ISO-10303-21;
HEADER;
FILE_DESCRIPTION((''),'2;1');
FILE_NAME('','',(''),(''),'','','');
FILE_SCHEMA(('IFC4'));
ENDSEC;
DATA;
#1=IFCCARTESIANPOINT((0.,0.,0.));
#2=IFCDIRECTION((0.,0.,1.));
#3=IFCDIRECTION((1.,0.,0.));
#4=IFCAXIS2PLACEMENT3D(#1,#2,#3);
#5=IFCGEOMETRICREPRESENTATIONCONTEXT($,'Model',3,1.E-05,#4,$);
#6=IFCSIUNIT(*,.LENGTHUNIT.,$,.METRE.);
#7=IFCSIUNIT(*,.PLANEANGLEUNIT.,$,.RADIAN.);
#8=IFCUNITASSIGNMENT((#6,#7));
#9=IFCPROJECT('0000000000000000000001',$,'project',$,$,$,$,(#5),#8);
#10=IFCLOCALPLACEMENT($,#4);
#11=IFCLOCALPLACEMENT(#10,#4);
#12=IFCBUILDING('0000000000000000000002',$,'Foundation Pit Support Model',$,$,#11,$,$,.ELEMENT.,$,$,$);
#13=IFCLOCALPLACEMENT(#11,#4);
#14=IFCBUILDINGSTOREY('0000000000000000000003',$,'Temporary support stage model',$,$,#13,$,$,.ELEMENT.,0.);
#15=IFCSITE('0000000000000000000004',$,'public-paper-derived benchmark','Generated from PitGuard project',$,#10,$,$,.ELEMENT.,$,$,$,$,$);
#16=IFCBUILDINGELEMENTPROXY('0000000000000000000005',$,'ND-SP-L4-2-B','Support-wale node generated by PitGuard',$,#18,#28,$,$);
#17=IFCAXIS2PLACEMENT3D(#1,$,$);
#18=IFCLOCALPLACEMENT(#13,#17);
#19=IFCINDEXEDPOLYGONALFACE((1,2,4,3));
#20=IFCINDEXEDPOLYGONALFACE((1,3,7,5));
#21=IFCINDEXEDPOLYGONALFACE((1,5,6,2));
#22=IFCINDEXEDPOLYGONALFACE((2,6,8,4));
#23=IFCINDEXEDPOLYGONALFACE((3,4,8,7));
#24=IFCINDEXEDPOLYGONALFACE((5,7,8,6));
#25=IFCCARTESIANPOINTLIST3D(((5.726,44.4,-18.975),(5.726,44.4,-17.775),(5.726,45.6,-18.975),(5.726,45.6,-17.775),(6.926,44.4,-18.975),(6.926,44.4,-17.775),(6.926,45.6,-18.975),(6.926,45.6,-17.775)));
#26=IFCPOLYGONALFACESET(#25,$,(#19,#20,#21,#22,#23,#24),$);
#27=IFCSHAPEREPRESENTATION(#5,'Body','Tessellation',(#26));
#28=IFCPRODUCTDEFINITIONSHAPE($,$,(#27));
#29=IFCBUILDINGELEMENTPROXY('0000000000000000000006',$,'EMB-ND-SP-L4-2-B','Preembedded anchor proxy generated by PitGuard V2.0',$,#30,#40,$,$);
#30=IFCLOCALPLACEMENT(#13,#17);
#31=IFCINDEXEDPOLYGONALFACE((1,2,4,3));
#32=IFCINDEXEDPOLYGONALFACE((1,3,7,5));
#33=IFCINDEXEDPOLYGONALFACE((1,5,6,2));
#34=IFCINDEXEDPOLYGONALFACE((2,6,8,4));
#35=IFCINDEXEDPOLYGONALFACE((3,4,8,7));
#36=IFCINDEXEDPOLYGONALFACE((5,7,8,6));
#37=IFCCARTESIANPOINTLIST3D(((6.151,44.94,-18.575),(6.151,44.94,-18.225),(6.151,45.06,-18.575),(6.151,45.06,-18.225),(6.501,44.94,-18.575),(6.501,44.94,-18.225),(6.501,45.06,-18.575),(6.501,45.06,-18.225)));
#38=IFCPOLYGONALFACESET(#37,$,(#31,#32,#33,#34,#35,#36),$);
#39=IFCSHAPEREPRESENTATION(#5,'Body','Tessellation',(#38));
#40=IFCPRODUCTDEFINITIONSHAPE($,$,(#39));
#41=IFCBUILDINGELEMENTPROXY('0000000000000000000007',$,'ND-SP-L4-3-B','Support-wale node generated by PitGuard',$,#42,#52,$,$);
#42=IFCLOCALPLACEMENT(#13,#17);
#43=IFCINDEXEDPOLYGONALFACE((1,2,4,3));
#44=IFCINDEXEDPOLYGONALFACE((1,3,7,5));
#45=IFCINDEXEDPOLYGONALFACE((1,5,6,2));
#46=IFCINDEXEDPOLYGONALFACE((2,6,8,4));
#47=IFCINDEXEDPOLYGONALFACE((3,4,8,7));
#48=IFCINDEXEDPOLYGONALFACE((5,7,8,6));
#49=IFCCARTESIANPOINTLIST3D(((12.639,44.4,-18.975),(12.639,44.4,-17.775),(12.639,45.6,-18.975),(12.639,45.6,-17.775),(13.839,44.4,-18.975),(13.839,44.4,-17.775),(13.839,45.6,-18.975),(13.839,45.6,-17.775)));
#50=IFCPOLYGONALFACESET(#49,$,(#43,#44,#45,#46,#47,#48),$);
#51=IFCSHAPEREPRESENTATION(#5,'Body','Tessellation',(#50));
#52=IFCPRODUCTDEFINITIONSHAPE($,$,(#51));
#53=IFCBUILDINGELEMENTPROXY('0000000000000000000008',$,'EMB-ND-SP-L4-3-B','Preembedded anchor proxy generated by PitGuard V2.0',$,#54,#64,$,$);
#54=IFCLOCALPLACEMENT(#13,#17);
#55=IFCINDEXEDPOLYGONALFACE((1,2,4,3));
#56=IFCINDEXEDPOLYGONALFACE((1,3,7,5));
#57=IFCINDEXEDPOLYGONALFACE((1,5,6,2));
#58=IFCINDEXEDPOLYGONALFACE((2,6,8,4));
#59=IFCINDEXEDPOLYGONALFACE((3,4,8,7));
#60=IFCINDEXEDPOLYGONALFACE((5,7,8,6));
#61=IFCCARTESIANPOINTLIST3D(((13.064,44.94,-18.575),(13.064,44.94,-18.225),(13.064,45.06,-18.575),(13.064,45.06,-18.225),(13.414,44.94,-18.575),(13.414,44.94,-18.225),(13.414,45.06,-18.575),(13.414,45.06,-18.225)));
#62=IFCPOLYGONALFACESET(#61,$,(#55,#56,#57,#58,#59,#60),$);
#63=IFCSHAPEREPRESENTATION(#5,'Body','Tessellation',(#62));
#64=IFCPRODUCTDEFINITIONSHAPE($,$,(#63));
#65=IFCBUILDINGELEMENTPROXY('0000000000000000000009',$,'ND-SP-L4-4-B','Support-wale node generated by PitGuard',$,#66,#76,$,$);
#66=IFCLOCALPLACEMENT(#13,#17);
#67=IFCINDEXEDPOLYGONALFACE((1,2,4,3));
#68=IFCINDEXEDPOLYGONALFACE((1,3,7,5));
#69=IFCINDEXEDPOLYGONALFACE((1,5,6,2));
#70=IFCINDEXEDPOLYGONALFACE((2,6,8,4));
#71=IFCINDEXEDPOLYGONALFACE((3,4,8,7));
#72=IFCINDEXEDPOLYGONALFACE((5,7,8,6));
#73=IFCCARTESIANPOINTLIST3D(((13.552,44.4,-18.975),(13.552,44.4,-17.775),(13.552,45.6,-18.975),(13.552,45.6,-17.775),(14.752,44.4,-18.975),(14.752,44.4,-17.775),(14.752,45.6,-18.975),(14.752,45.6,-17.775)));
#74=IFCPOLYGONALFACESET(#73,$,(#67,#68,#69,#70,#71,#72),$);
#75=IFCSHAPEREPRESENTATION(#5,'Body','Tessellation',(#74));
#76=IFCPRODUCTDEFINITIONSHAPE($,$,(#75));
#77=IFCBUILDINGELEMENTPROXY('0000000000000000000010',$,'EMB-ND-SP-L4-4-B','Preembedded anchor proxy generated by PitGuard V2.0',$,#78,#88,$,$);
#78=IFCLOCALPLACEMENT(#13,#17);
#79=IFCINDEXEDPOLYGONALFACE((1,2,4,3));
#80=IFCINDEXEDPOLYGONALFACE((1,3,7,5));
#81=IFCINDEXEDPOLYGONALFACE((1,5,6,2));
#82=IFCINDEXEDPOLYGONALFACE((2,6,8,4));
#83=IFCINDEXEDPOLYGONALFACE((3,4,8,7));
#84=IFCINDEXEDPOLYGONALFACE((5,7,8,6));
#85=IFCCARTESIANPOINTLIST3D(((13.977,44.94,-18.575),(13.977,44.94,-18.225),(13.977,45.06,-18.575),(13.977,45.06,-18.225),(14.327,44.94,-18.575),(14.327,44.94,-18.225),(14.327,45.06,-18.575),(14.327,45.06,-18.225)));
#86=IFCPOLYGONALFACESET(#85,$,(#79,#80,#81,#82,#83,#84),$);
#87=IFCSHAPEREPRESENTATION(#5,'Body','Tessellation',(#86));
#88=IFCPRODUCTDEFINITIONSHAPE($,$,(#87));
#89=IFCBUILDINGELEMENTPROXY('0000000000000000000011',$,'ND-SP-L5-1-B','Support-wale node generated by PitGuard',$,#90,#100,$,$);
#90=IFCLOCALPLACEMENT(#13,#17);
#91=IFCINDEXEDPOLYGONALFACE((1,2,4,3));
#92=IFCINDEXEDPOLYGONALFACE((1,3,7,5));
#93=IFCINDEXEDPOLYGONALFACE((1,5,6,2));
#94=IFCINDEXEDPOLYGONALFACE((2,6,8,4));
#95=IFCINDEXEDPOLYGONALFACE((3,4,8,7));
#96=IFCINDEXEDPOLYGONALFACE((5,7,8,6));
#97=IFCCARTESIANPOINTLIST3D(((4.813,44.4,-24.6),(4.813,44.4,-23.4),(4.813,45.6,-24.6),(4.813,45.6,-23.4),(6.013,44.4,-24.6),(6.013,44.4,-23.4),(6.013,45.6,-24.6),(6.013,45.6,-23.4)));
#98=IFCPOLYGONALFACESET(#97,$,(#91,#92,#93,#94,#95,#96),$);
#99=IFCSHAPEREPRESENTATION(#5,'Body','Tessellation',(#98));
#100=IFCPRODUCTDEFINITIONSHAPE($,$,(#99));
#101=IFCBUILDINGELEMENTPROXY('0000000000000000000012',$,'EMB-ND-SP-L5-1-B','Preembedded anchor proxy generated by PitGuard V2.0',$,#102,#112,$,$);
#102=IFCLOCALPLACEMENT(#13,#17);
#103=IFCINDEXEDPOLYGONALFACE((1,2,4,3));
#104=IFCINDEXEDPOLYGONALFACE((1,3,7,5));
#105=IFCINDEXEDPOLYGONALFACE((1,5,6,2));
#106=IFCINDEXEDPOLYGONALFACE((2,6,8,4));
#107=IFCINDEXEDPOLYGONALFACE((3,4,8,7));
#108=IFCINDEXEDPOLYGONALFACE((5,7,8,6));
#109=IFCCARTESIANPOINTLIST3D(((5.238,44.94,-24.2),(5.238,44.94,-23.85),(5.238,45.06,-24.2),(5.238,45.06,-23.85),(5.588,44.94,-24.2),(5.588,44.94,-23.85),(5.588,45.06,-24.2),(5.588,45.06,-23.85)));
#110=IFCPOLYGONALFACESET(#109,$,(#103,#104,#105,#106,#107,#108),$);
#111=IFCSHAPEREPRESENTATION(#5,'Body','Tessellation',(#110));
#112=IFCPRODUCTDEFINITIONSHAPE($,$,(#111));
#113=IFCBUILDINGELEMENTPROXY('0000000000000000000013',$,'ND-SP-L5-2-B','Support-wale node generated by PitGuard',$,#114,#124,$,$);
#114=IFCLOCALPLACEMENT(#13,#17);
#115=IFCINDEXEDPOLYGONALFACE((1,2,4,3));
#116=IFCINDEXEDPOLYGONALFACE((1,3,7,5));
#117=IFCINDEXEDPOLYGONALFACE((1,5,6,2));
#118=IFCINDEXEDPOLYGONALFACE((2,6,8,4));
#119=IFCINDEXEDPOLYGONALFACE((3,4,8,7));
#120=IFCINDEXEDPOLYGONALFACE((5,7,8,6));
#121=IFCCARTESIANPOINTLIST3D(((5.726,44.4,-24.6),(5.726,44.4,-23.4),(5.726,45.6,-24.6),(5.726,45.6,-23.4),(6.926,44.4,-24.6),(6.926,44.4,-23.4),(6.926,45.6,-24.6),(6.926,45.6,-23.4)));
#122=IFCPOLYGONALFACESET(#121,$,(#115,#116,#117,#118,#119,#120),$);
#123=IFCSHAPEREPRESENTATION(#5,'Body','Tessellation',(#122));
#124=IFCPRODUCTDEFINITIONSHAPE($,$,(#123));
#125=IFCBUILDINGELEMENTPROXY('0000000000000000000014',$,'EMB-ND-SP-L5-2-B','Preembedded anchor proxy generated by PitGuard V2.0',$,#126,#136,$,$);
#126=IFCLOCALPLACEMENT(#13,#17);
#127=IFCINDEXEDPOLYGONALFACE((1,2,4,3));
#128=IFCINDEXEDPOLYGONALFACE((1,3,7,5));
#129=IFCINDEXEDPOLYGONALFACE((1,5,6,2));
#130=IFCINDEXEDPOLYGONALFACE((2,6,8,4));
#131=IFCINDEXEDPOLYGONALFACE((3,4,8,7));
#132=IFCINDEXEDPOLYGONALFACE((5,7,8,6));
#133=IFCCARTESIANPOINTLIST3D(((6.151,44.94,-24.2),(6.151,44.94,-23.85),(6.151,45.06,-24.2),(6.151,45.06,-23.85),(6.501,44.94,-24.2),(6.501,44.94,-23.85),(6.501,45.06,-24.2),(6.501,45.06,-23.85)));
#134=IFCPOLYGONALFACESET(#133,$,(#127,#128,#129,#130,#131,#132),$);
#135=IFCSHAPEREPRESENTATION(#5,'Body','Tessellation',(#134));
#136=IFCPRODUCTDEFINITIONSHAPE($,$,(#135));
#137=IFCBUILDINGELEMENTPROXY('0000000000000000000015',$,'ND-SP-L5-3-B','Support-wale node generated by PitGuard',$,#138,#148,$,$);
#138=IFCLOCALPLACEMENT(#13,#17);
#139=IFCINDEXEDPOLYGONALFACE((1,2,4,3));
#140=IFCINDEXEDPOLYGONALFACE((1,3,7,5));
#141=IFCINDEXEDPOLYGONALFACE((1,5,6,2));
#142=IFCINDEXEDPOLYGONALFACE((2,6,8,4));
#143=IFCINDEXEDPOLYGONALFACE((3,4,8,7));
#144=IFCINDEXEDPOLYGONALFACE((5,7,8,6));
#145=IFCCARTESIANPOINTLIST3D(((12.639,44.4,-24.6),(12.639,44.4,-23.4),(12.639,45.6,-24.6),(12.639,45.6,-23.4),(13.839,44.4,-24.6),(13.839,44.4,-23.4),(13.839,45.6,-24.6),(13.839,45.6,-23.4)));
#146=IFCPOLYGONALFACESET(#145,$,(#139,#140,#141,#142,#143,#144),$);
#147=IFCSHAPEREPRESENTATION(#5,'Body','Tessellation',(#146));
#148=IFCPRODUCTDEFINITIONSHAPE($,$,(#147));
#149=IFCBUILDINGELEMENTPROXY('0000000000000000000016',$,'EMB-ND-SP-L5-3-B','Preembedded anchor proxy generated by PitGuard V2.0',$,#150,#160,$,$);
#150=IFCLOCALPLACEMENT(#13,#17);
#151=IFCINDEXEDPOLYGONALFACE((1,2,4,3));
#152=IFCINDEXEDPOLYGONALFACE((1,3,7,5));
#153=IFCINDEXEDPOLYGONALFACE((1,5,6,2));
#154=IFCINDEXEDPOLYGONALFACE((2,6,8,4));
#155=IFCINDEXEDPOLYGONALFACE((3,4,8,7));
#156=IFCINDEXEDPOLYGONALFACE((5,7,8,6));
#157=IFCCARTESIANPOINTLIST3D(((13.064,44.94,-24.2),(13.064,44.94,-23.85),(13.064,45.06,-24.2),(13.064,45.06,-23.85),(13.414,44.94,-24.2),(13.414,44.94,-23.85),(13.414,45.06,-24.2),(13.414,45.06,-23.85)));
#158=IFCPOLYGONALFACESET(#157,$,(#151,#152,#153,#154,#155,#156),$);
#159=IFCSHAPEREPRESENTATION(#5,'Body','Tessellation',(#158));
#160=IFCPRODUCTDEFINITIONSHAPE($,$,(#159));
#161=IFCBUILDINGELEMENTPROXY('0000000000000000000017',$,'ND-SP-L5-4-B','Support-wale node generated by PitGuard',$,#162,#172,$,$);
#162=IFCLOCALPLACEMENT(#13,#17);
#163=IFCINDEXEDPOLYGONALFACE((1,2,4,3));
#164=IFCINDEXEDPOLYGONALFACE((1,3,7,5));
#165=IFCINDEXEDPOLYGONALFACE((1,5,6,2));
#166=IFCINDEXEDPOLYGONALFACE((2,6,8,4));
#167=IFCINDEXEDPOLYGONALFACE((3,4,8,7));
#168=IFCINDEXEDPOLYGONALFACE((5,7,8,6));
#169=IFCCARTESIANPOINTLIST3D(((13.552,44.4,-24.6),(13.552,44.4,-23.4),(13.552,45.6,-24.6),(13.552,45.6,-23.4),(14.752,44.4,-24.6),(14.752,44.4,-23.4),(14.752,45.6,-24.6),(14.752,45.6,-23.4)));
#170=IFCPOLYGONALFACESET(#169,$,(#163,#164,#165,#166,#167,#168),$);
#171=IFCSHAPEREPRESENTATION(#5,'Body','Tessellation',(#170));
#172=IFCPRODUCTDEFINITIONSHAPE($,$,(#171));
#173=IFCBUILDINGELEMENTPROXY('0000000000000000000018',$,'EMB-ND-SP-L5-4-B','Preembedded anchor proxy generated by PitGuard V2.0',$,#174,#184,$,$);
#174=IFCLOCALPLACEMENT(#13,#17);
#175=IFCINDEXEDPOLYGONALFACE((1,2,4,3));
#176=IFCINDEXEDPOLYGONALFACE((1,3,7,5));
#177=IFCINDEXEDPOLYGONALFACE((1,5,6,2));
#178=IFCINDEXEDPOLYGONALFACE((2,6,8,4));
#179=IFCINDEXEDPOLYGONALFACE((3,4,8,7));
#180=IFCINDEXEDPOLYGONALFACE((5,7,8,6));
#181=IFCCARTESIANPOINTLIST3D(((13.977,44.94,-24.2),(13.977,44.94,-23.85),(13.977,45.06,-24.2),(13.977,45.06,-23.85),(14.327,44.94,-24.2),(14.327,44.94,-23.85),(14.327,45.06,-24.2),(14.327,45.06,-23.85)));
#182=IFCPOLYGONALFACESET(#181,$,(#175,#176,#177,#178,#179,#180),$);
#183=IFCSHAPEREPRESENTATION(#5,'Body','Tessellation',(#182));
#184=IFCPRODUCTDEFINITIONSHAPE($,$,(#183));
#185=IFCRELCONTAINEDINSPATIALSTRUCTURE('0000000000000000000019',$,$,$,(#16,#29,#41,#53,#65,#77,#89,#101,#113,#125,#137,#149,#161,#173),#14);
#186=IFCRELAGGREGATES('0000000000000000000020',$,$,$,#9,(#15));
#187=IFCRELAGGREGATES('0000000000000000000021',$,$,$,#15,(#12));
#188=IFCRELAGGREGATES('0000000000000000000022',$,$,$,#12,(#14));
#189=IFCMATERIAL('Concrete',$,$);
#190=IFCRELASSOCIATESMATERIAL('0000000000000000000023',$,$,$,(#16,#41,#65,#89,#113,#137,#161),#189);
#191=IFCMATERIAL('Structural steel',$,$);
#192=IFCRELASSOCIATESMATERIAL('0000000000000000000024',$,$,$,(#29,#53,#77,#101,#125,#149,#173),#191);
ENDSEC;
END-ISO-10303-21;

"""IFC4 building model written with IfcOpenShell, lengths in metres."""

from ifc_helpers import new_model, si_unit, frame, origin_with_axes, origin_2d, place, context, project, spatial, rectangle, extrude, material, element, save


model = new_model("IFC4")

# Units and contexts
model_context = context("Model", 3, precision=1e-05, world=origin_with_axes())
ifc_project = project(units=[si_unit("LENGTHUNIT", "METRE"), si_unit("PLANEANGLEUNIT", "RADIAN")], contexts=[model_context])

# Site, building, storey
site_placement = place(None, origin_with_axes())
site = spatial("IfcSite", under=ifc_project, at=site_placement, Name="public-paper-derived benchmark", Description="Generated from PitGuard project", CompositionType="ELEMENT")
building_placement = place(site_placement, origin_with_axes())
building = spatial("IfcBuilding", under=site, at=building_placement, Name="Foundation Pit Support Model", CompositionType="ELEMENT")
storey_placement = place(building_placement, origin_with_axes())
storey = spatial("IfcBuildingStorey", under=building, at=storey_placement, Name="Temporary support stage model", CompositionType="ELEMENT", Elevation=0.0)

# Shared definitions
ifc_material_1 = material(Name="Structural steel")

# Building element proxies
ifc_material_2 = material(Name="Concrete")
proxy_1_placement = place(storey_placement, frame((6.326, 45.0, -18.975), z_axis=(0.0, 0.0, 1.0), x_axis=(1.0, 0.0, 0.0)))
element("IfcBuildingElementProxy", 1, at=proxy_1_placement, inside=storey, material=ifc_material_2, Name="ND-SP-L4-2-B", Description="Support-wale node generated by PitGuard", context=model_context, shape_type="SweptSolid", body=[
    extrude(rectangle(XDim=1.2, YDim=1.2, at=origin_2d()), origin_with_axes(), (0.0, 0.0, 1.0), 1.2),
])
proxy_2_placement = place(storey_placement, frame((6.326, 45.0, -18.575), z_axis=(0.0, 0.0, 1.0), x_axis=(1.0, 0.0, 0.0)))
element("IfcBuildingElementProxy", 2, at=proxy_2_placement, inside=storey, material=ifc_material_1, Name="EMB-ND-SP-L4-2-B", Description="Preembedded anchor proxy generated by PitGuard V2.0", context=model_context, shape_type="SweptSolid", body=[
    extrude(rectangle(XDim=0.35, YDim=0.12, at=origin_2d()), origin_with_axes(), (0.0, 0.0, 1.0), 0.35),
])
proxy_3_placement = place(storey_placement, frame((13.239, 45.0, -18.975), z_axis=(0.0, 0.0, 1.0), x_axis=(1.0, 0.0, 0.0)))
element("IfcBuildingElementProxy", 3, at=proxy_3_placement, inside=storey, material=ifc_material_2, Name="ND-SP-L4-3-B", Description="Support-wale node generated by PitGuard", context=model_context, shape_type="SweptSolid", body=[
    extrude(rectangle(XDim=1.2, YDim=1.2, at=origin_2d()), origin_with_axes(), (0.0, 0.0, 1.0), 1.2),
])
proxy_4_placement = place(storey_placement, frame((13.239, 45.0, -18.575), z_axis=(0.0, 0.0, 1.0), x_axis=(1.0, 0.0, 0.0)))
element("IfcBuildingElementProxy", 4, at=proxy_4_placement, inside=storey, material=ifc_material_1, Name="EMB-ND-SP-L4-3-B", Description="Preembedded anchor proxy generated by PitGuard V2.0", context=model_context, shape_type="SweptSolid", body=[
    extrude(rectangle(XDim=0.35, YDim=0.12, at=origin_2d()), origin_with_axes(), (0.0, 0.0, 1.0), 0.35),
])
proxy_5_placement = place(storey_placement, frame((14.152, 45.0, -18.975), z_axis=(0.0, 0.0, 1.0), x_axis=(1.0, 0.0, 0.0)))
element("IfcBuildingElementProxy", 5, at=proxy_5_placement, inside=storey, material=ifc_material_2, Name="ND-SP-L4-4-B", Description="Support-wale node generated by PitGuard", context=model_context, shape_type="SweptSolid", body=[
    extrude(rectangle(XDim=1.2, YDim=1.2, at=origin_2d()), origin_with_axes(), (0.0, 0.0, 1.0), 1.2),
])
proxy_6_placement = place(storey_placement, frame((14.152, 45.0, -18.575), z_axis=(0.0, 0.0, 1.0), x_axis=(1.0, 0.0, 0.0)))
element("IfcBuildingElementProxy", 6, at=proxy_6_placement, inside=storey, material=ifc_material_1, Name="EMB-ND-SP-L4-4-B", Description="Preembedded anchor proxy generated by PitGuard V2.0", context=model_context, shape_type="SweptSolid", body=[
    extrude(rectangle(XDim=0.35, YDim=0.12, at=origin_2d()), origin_with_axes(), (0.0, 0.0, 1.0), 0.35),
])
proxy_7_placement = place(storey_placement, frame((5.413, 45.0, -24.6), z_axis=(0.0, 0.0, 1.0), x_axis=(1.0, 0.0, 0.0)))
element("IfcBuildingElementProxy", 7, at=proxy_7_placement, inside=storey, material=ifc_material_2, Name="ND-SP-L5-1-B", Description="Support-wale node generated by PitGuard", context=model_context, shape_type="SweptSolid", body=[
    extrude(rectangle(XDim=1.2, YDim=1.2, at=origin_2d()), origin_with_axes(), (0.0, 0.0, 1.0), 1.2),
])
proxy_8_placement = place(storey_placement, frame((5.413, 45.0, -24.2), z_axis=(0.0, 0.0, 1.0), x_axis=(1.0, 0.0, 0.0)))
element("IfcBuildingElementProxy", 8, at=proxy_8_placement, inside=storey, material=ifc_material_1, Name="EMB-ND-SP-L5-1-B", Description="Preembedded anchor proxy generated by PitGuard V2.0", context=model_context, shape_type="SweptSolid", body=[
    extrude(rectangle(XDim=0.35, YDim=0.12, at=origin_2d()), origin_with_axes(), (0.0, 0.0, 1.0), 0.35),
])
proxy_9_placement = place(storey_placement, frame((6.326, 45.0, -24.6), z_axis=(0.0, 0.0, 1.0), x_axis=(1.0, 0.0, 0.0)))
element("IfcBuildingElementProxy", 9, at=proxy_9_placement, inside=storey, material=ifc_material_2, Name="ND-SP-L5-2-B", Description="Support-wale node generated by PitGuard", context=model_context, shape_type="SweptSolid", body=[
    extrude(rectangle(XDim=1.2, YDim=1.2, at=origin_2d()), origin_with_axes(), (0.0, 0.0, 1.0), 1.2),
])
proxy_10_placement = place(storey_placement, frame((6.326, 45.0, -24.2), z_axis=(0.0, 0.0, 1.0), x_axis=(1.0, 0.0, 0.0)))
element("IfcBuildingElementProxy", 10, at=proxy_10_placement, inside=storey, material=ifc_material_1, Name="EMB-ND-SP-L5-2-B", Description="Preembedded anchor proxy generated by PitGuard V2.0", context=model_context, shape_type="SweptSolid", body=[
    extrude(rectangle(XDim=0.35, YDim=0.12, at=origin_2d()), origin_with_axes(), (0.0, 0.0, 1.0), 0.35),
])
proxy_11_placement = place(storey_placement, frame((13.239, 45.0, -24.6), z_axis=(0.0, 0.0, 1.0), x_axis=(1.0, 0.0, 0.0)))
element("IfcBuildingElementProxy", 11, at=proxy_11_placement, inside=storey, material=ifc_material_2, Name="ND-SP-L5-3-B", Description="Support-wale node generated by PitGuard", context=model_context, shape_type="SweptSolid", body=[
    extrude(rectangle(XDim=1.2, YDim=1.2, at=origin_2d()), origin_with_axes(), (0.0, 0.0, 1.0), 1.2),
])
proxy_12_placement = place(storey_placement, frame((13.239, 45.0, -24.2), z_axis=(0.0, 0.0, 1.0), x_axis=(1.0, 0.0, 0.0)))
element("IfcBuildingElementProxy", 12, at=proxy_12_placement, inside=storey, material=ifc_material_1, Name="EMB-ND-SP-L5-3-B", Description="Preembedded anchor proxy generated by PitGuard V2.0", context=model_context, shape_type="SweptSolid", body=[
    extrude(rectangle(XDim=0.35, YDim=0.12, at=origin_2d()), origin_with_axes(), (0.0, 0.0, 1.0), 0.35),
])
proxy_13_placement = place(storey_placement, frame((14.152, 45.0, -24.6), z_axis=(0.0, 0.0, 1.0), x_axis=(1.0, 0.0, 0.0)))
element("IfcBuildingElementProxy", 13, at=proxy_13_placement, inside=storey, material=ifc_material_2, Name="ND-SP-L5-4-B", Description="Support-wale node generated by PitGuard", context=model_context, shape_type="SweptSolid", body=[
    extrude(rectangle(XDim=1.2, YDim=1.2, at=origin_2d()), origin_with_axes(), (0.0, 0.0, 1.0), 1.2),
])
proxy_14_placement = place(storey_placement, frame((14.152, 45.0, -24.2), z_axis=(0.0, 0.0, 1.0), x_axis=(1.0, 0.0, 0.0)))
element("IfcBuildingElementProxy", 14, at=proxy_14_placement, inside=storey, material=ifc_material_1, Name="EMB-ND-SP-L5-4-B", Description="Preembedded anchor proxy generated by PitGuard V2.0", context=model_context, shape_type="SweptSolid", body=[
    extrude(rectangle(XDim=0.35, YDim=0.12, at=origin_2d()), origin_with_axes(), (0.0, 0.0, 1.0), 0.35),
])

save(model, "model.ifc")
